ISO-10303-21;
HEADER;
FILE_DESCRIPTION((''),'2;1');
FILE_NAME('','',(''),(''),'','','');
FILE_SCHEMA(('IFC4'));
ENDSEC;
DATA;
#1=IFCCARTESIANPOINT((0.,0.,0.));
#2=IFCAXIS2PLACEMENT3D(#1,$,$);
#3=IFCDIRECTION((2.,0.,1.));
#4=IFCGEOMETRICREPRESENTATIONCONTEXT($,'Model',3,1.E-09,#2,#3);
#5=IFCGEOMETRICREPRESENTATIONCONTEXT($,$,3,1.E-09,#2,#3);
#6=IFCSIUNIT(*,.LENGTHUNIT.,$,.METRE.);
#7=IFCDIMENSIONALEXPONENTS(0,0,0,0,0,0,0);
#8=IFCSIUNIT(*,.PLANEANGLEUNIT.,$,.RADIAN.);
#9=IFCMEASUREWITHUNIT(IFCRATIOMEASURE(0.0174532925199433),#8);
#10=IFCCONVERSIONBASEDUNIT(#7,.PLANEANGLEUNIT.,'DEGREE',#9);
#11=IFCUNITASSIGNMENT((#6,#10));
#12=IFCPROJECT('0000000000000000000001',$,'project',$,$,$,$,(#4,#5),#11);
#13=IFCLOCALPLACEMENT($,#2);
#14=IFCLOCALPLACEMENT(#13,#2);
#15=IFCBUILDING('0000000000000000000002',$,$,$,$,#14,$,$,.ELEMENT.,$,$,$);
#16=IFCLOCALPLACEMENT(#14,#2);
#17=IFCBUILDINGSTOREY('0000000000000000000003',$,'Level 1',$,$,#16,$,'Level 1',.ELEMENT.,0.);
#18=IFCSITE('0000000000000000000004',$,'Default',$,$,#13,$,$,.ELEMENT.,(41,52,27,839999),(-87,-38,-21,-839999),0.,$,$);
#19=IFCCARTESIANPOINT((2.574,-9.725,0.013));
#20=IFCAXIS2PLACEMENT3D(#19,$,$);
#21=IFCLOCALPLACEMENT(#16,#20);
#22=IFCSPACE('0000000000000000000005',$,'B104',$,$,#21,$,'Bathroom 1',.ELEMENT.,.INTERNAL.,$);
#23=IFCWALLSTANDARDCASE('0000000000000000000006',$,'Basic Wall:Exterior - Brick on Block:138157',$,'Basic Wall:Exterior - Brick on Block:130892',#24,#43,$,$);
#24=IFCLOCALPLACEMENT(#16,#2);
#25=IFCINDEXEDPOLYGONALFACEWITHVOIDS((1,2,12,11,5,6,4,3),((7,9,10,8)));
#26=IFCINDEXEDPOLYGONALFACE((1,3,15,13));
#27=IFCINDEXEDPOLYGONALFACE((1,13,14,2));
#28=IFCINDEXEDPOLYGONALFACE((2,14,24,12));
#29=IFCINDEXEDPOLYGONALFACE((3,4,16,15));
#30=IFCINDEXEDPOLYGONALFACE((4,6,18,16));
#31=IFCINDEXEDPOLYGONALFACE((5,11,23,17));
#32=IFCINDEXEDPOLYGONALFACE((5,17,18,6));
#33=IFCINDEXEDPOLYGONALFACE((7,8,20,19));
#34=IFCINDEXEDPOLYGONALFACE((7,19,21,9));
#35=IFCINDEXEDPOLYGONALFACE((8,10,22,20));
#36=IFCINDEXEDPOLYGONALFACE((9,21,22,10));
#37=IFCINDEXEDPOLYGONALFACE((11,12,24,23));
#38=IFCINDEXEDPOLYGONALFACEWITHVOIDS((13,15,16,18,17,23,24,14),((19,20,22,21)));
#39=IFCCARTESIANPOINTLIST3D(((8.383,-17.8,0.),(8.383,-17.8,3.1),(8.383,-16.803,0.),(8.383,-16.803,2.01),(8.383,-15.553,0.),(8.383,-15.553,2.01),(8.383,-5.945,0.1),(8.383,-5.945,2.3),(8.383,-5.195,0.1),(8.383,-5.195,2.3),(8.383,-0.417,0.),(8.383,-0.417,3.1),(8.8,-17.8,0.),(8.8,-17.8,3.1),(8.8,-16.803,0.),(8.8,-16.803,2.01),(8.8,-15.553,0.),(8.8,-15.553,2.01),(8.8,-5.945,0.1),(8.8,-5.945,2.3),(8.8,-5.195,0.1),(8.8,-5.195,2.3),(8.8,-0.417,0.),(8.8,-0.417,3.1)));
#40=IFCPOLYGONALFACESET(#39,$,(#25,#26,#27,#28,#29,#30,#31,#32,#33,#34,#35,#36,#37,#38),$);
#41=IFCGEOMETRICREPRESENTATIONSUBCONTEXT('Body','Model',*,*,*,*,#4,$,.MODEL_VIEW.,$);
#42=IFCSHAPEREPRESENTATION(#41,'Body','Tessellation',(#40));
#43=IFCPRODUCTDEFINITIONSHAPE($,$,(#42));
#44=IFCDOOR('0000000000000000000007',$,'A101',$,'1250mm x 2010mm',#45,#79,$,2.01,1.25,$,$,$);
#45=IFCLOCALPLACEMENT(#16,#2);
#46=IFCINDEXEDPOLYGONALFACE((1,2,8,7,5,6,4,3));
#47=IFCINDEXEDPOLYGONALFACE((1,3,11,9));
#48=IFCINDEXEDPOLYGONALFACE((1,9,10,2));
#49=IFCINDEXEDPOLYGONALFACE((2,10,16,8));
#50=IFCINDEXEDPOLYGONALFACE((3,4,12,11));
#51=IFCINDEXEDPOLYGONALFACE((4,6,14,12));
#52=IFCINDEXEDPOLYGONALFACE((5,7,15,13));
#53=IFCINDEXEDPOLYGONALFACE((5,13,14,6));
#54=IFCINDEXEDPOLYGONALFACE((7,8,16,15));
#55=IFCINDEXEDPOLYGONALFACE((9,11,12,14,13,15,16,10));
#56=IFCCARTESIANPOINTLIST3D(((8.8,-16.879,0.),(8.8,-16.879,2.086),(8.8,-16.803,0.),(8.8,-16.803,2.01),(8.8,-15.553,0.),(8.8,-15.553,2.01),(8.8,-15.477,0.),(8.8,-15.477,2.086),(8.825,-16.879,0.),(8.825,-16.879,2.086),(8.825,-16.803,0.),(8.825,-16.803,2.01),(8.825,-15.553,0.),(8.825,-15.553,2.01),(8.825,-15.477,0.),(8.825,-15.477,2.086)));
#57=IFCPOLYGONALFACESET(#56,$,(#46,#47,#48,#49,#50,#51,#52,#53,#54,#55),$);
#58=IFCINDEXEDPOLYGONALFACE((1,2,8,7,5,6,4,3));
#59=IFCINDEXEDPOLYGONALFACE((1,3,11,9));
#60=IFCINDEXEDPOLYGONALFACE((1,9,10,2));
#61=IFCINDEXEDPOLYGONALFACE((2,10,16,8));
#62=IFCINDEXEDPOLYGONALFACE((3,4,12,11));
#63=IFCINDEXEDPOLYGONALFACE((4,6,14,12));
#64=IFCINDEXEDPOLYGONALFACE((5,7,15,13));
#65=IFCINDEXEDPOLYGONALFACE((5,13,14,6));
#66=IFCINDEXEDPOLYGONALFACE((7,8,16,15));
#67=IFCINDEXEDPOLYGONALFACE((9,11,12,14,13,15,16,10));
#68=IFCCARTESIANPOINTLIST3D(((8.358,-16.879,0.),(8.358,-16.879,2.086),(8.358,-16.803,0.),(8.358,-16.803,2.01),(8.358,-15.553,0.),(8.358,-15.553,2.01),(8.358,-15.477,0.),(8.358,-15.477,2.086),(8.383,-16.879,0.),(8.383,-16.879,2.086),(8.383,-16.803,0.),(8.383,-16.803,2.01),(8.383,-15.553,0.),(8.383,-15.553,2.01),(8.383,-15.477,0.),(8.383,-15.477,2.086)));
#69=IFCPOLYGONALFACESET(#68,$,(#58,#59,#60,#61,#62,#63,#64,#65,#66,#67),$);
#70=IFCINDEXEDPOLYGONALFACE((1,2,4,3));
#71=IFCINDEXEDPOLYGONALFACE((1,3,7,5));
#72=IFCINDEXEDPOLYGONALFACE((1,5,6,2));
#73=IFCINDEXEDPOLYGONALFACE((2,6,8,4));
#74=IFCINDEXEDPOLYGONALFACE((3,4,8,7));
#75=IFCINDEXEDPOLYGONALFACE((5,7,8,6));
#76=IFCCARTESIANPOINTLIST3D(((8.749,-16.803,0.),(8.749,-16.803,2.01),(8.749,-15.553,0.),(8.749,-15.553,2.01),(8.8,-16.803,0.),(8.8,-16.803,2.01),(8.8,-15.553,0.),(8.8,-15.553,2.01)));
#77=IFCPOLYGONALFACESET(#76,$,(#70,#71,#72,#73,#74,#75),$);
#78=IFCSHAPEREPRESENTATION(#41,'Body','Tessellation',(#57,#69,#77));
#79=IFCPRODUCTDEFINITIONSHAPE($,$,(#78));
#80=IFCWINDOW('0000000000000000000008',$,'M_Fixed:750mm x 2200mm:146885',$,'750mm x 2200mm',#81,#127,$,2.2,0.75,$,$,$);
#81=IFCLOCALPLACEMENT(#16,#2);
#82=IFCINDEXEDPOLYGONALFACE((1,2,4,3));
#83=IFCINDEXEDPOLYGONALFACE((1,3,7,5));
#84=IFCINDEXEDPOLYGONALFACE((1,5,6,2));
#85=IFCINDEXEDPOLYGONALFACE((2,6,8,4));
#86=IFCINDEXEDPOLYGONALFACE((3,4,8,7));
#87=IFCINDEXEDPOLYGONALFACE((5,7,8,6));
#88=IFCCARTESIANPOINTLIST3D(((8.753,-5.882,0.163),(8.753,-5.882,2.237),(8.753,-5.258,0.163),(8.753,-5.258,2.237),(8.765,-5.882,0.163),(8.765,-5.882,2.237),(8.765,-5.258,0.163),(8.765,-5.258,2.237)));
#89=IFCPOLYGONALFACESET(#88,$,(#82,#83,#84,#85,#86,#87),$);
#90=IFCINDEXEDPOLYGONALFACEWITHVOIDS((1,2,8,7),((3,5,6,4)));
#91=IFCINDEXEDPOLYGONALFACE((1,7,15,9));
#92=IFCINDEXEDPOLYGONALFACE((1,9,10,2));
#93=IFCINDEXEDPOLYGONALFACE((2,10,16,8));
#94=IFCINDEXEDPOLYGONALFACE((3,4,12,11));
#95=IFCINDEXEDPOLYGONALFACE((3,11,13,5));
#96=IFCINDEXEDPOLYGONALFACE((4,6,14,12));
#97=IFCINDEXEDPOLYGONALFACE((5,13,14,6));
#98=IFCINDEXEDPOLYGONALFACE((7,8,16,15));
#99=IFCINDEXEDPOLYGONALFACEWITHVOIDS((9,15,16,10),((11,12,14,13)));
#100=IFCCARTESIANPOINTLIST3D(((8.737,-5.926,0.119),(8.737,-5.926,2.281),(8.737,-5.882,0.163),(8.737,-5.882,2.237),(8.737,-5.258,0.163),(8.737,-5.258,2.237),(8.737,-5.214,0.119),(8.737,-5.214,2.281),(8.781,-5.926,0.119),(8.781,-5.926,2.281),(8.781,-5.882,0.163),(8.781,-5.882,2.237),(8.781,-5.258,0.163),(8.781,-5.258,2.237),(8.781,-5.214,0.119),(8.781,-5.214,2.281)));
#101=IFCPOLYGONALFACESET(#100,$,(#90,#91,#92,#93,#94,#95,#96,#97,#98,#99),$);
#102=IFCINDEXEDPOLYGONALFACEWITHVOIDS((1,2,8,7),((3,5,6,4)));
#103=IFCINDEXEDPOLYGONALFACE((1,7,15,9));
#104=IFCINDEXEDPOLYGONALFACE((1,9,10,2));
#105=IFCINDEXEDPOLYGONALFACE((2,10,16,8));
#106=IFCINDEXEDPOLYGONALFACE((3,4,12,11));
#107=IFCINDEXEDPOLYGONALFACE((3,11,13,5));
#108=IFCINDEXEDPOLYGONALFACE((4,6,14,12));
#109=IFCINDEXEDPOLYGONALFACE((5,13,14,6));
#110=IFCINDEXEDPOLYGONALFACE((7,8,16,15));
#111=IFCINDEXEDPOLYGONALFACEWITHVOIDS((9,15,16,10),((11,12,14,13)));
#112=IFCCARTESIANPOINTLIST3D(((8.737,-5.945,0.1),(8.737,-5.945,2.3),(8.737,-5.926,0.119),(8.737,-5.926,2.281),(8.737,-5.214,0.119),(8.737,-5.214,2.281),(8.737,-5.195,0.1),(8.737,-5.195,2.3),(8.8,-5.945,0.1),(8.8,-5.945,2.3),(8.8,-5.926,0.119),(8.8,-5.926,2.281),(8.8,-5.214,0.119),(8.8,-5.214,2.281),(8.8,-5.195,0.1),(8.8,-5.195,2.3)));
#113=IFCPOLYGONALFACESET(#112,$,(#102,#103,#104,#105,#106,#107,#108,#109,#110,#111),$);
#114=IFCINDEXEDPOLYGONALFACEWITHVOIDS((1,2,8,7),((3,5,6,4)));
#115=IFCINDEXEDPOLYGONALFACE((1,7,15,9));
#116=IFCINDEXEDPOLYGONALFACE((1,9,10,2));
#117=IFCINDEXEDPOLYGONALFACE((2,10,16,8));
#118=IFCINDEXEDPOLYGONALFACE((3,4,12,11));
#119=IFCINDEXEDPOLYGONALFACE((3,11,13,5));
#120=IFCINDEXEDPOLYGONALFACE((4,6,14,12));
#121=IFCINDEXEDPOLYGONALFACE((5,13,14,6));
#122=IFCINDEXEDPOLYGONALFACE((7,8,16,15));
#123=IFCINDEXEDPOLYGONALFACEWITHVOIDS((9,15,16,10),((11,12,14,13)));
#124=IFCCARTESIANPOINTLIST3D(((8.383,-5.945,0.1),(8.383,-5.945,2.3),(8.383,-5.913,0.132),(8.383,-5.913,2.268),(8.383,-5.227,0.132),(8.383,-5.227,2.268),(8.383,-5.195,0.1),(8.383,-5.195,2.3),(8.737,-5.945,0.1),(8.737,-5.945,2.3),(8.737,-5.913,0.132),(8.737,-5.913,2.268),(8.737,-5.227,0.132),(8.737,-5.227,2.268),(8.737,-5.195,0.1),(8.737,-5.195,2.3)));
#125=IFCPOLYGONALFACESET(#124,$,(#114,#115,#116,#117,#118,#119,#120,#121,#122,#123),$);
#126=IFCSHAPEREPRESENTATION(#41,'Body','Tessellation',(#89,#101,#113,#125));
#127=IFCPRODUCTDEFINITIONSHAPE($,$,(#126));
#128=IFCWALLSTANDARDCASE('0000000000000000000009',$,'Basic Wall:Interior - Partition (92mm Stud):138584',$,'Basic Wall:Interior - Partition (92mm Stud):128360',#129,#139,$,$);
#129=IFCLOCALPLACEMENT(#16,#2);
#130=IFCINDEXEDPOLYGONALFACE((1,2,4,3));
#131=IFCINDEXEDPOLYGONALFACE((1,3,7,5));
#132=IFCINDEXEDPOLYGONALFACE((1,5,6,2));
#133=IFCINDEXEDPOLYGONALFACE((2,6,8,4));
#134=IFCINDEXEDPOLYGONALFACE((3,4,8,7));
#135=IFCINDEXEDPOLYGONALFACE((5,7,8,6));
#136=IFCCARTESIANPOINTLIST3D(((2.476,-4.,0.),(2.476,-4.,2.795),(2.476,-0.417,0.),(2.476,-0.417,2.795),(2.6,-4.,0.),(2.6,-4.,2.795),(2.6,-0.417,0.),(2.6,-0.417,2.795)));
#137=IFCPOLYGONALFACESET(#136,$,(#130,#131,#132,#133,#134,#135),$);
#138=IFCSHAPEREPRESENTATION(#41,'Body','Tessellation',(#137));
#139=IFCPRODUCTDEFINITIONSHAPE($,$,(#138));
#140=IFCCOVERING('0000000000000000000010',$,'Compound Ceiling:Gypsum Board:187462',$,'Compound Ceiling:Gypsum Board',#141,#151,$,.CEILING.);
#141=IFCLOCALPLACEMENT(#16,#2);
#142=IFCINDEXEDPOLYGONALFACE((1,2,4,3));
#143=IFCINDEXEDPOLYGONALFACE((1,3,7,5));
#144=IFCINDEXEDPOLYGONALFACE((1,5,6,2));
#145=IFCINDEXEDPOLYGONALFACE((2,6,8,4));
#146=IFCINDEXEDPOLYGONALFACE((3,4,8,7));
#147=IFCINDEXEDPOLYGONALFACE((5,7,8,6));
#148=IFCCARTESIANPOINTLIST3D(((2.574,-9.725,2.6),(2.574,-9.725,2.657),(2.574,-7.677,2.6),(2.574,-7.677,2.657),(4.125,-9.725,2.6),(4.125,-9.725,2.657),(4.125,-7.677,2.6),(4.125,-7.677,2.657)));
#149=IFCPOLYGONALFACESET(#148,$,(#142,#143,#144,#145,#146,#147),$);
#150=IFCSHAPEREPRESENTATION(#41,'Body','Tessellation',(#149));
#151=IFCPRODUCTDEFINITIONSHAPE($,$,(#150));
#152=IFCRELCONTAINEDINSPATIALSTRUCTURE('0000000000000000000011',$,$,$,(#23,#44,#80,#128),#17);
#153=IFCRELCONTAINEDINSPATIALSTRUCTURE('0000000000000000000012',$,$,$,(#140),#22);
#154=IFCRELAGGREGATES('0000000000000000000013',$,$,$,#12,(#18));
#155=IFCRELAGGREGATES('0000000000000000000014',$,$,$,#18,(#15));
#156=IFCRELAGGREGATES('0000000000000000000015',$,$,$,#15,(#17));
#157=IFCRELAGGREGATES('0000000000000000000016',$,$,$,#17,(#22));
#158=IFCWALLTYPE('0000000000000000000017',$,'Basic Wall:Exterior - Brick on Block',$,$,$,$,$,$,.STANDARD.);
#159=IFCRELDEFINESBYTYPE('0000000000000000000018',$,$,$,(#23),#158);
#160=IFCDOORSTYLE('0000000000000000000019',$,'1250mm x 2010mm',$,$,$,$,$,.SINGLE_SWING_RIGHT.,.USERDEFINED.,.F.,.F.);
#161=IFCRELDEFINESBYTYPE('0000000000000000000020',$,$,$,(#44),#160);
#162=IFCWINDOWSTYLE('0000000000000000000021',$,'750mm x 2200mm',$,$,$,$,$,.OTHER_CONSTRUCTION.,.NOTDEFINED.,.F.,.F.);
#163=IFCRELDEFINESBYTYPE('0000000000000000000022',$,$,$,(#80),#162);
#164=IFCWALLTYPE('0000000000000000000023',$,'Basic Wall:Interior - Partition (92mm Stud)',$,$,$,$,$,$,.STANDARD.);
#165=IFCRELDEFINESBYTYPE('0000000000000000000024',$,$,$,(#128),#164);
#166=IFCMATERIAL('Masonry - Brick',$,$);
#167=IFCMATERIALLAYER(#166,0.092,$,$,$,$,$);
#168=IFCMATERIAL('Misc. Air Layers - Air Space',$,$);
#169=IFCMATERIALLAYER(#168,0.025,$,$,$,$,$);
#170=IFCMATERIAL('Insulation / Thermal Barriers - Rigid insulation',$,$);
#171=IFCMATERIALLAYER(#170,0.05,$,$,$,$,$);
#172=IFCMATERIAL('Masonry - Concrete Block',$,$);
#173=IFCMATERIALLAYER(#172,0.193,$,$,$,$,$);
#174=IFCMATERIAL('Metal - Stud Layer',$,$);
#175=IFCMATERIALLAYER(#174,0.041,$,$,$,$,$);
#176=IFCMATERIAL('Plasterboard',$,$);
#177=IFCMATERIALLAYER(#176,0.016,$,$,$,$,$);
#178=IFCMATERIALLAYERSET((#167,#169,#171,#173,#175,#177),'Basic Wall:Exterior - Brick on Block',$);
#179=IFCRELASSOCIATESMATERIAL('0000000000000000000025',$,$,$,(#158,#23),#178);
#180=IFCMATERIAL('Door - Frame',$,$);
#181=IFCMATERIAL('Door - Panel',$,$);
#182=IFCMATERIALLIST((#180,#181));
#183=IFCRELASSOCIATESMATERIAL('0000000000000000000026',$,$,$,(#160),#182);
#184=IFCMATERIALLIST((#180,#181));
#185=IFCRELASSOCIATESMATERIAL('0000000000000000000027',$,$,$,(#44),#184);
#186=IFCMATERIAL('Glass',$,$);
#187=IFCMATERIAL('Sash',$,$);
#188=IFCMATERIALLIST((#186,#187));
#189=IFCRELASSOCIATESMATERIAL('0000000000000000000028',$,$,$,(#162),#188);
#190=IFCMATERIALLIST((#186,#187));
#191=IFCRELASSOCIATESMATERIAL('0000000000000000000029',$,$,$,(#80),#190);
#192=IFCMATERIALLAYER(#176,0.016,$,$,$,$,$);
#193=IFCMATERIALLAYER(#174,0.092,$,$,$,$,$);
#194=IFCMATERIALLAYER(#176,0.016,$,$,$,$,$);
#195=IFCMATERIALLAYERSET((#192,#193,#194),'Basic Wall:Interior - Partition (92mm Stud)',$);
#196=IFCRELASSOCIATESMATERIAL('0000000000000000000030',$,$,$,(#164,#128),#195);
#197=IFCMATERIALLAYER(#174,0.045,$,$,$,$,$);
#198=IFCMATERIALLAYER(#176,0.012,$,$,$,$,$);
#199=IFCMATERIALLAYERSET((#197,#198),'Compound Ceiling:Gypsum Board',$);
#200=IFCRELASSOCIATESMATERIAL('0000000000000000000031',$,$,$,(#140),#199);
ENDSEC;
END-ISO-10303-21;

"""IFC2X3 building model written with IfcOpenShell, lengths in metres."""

from ifc_helpers import new_model, entity, si_unit, converted_unit, direction, frame, frame_2d, origin, origin_2d_with_axis, place, context, subcontext, project, spatial, polyline, rectangle, outline, extrude, source, transform, mapped, material, material_list, layer, layer_set, layer_usage, type_object, type_shapes, element, fill, save


model = new_model("IFC2X3")

# Units and contexts
model_context = context("Model", 3, precision=1e-09, world=origin(), true_north=direction((2.0, 0.0, 1.0)))
context_of_model = context(None, 3, precision=1e-09, world=origin(), true_north=direction((2.0, 0.0, 1.0)))
body_context = subcontext(model_context, "Body", "Model", "MODEL_VIEW")
ifc_project = project(units=[si_unit("LENGTHUNIT", "METRE"), converted_unit("PLANEANGLEUNIT", "DEGREE", entity("IfcRatioMeasure", 0.0174532925199433), si_unit("PLANEANGLEUNIT", "RADIAN"), dimensions=[0, 0, 0, 0, 0, 0, 0])], contexts=[model_context, context_of_model])

# Site, building, storey
site_placement = place(None, origin())
site = spatial("IfcSite", under=ifc_project, at=site_placement, Name="Default", CompositionType="ELEMENT", RefLatitude=(41, 52, 27, 839999), RefLongitude=(-87, -38, -21, -839999), RefElevation=0.0)
building_placement = place(site_placement, origin())
building = spatial("IfcBuilding", under=site, at=building_placement, CompositionType="ELEMENT")
storey_placement = place(building_placement, origin())
storey = spatial("IfcBuildingStorey", under=building, at=storey_placement, Name="Level 1", LongName="Level 1", CompositionType="ELEMENT", Elevation=0.0)

# Shared definitions
ifc_material_1 = material(Name="Masonry - Brick")
ifc_layer_1 = layer(ifc_material_1, 0.092)
ifc_material_2 = material(Name="Misc. Air Layers - Air Space")
ifc_layer_2 = layer(ifc_material_2, 0.025)
ifc_material_3 = material(Name="Insulation / Thermal Barriers - Rigid insulation")
ifc_layer_3 = layer(ifc_material_3, 0.05)
ifc_material_4 = material(Name="Masonry - Concrete Block")
ifc_layer_4 = layer(ifc_material_4, 0.193)
ifc_material_5 = material(Name="Metal - Stud Layer")
ifc_layer_5 = layer(ifc_material_5, 0.041)
ifc_material_6 = material(Name="Plasterboard")
ifc_layer_6 = layer(ifc_material_6, 0.016)
ifc_layer_set_1 = layer_set([ifc_layer_1, ifc_layer_2, ifc_layer_3, ifc_layer_4, ifc_layer_5, ifc_layer_6], Name="Basic Wall:Exterior - Brick on Block")
wall_type_1 = type_object("IfcWallType", Name="Basic Wall:Exterior - Brick on Block", PredefinedType="STANDARD", material=ifc_layer_set_1)
ifc_material_7 = material(Name="Glass")
ifc_material_8 = material(Name="Sash")
ifc_material_9 = material(Name="Door - Frame")
ifc_material_10 = material(Name="Door - Panel")

# Wall, openings, door, window
ifc_layer_usage_1 = layer_usage(ifc_layer_set_1, "AXIS2", "NEGATIVE", 0.2085)
wall_1_placement = place(storey_placement, frame((8.5915, -0.417, 0.0), z_axis=(0.0, 0.0, 1.0), x_axis=(0.0, -1.0, 0.0)))
wall_1 = element("IfcWallStandardCase", 1, at=wall_1_placement, inside=storey, type_object=wall_type_1, material=ifc_layer_usage_1, Name="Basic Wall:Exterior - Brick on Block:138157", ObjectType="Basic Wall:Exterior - Brick on Block:130892", context=body_context, shape_type="SweptSolid", body=[
    extrude(rectangle(XDim=17.383, YDim=0.417, at=frame_2d((8.6915, 0.0), x_axis=(-1.0, 0.0))), origin(), (0.0, 0.0, 1.0), 3.1),
])
opening_1_placement = place(wall_1_placement, frame((15.136, -0.2085, 0.0)))
opening_1 = element("IfcOpeningElement", 2, at=opening_1_placement, cuts=wall_1, ObjectType="Opening", context=body_context, shape_type="SweptSolid", body=[
    extrude(rectangle(XDim=1.25, YDim=2.01, at=frame_2d((1.005, 0.625), x_axis=(0.0, 1.0))), frame((0.0, 0.0, 0.0), z_axis=(0.0, 1.0, 0.0), x_axis=(0.0, 0.0, 1.0)), (0.0, 0.0, 1.0), 0.417),
])
opening_2_placement = place(wall_1_placement, frame((4.778, -0.2085, 0.1)))
opening_2 = element("IfcOpeningElement", 3, at=opening_2_placement, cuts=wall_1, ObjectType="Opening", context=body_context, shape_type="SweptSolid", body=[
    extrude(rectangle(XDim=2.2, YDim=0.75, at=frame_2d((1.1, 0.375), x_axis=(1.0, 0.0))), frame((0.0, 0.0, 0.0), z_axis=(0.0, 1.0, 0.0), x_axis=(0.0, 0.0, 1.0)), (0.0, 0.0, 1.0), 0.417),
])
ifc_material_list_1 = material_list([ifc_material_9, ifc_material_10])
ifc_material_list_2 = material_list([ifc_material_9, ifc_material_10])
door_style_1 = type_object("IfcDoorStyle", Name="1250mm x 2010mm", ConstructionType="USERDEFINED", OperationType="SINGLE_SWING_RIGHT", ParameterTakesPrecedence=False, Sizeable=False, material=ifc_material_list_2)
shared_shape_1 = source(origin(), body_context, "Body", "SweptSolid", [
    extrude(outline(polyline([(-0.701, -1.062), (0.701, -1.062), (0.701, 1.024), (0.625, 1.024), (0.625, -0.986), (-0.625, -0.986), (-0.625, 1.024), (-0.701, 1.024), (-0.701, -1.062)])), frame((0.625, 0.417, 1.024), z_axis=(0.0, 1.0, 0.0), x_axis=(1.0, 0.0, 0.0)), (0.0, 0.0, 1.0), 0.025),
    extrude(outline(polyline([(-1.062, -0.701), (1.024, -0.701), (1.024, -0.625), (-0.986, -0.625), (-0.986, 0.625), (1.024, 0.625), (1.024, 0.701), (-1.062, 0.701), (-1.062, -0.701)])), frame((0.625, -0.025, 1.024), z_axis=(0.0, 1.0, 0.0), x_axis=(0.0, 0.0, -1.0)), (0.0, 0.0, 1.0), 0.025),
    extrude(rectangle(XDim=0.051, YDim=1.25, at=frame_2d((0.0, 0.0), x_axis=(1.0, 0.0))), frame((0.625, 0.3915, 0.0), z_axis=(0.0, 0.0, 1.0), x_axis=(0.0, 1.0, 0.0)), (0.0, 0.0, 1.0), 2.01),
])
type_shapes(door_style_1, [shared_shape_1])
door_1_placement = place(opening_1_placement, origin())
door_1 = element("IfcDoor", 4, at=door_1_placement, inside=storey, type_object=door_style_1, material=ifc_material_list_1, Name="A101", ObjectType="1250mm x 2010mm", OverallHeight=2.01, OverallWidth=1.25, context=body_context, shape_type="MappedRepresentation", body=[
    mapped(shared_shape_1, transform((0.0, 0.0, 0.0), scale=1.0)),
])
fill(opening_1, door_1)
ifc_material_list_3 = material_list([ifc_material_7, ifc_material_8])
ifc_material_list_4 = material_list([ifc_material_7, ifc_material_8])
window_style_1 = type_object("IfcWindowStyle", Name="750mm x 2200mm", ConstructionType="OTHER_CONSTRUCTION", OperationType="NOTDEFINED", ParameterTakesPrecedence=False, Sizeable=False, material=ifc_material_list_4)
shared_shape_2 = source(origin(), body_context, "Body", "SweptSolid", [
    extrude(rectangle(XDim=0.012, YDim=0.624, at=origin_2d_with_axis()), frame((0.375, 0.376, 0.063), z_axis=(0.0, 0.0, 1.0), x_axis=(0.0, -1.0, 0.0)), (0.0, 0.0, 1.0), 2.074),
    extrude(outline(polyline([(-0.356, -1.081), (0.356, -1.081), (0.356, 1.081), (-0.356, 1.081), (-0.356, -1.081)]), holes=[polyline([(-0.312, -1.037), (-0.312, 1.037), (0.312, 1.037), (0.312, -1.037), (-0.312, -1.037)])]), frame((0.375, 0.354, 1.1), z_axis=(0.0, 1.0, 0.0), x_axis=(1.0, 0.0, 0.0)), (0.0, 0.0, 1.0), 0.044),
    extrude(outline(polyline([(-0.375, -1.1), (0.375, -1.1), (0.375, 1.1), (-0.375, 1.1), (-0.375, -1.1)]), holes=[polyline([(-0.356, -1.081), (-0.356, 1.081), (0.356, 1.081), (0.356, -1.081), (-0.356, -1.081)])]), frame((0.375, 0.354, 1.1), z_axis=(0.0, 1.0, 0.0), x_axis=(1.0, 0.0, 0.0)), (0.0, 0.0, 1.0), 0.063),
    extrude(outline(polyline([(-0.375, -1.1), (0.375, -1.1), (0.375, 1.1), (-0.375, 1.1), (-0.375, -1.1)]), holes=[polyline([(-0.343, -1.068), (-0.343, 1.068), (0.343, 1.068), (0.343, -1.068), (-0.343, -1.068)])]), frame((0.375, 0.0, 1.1), z_axis=(0.0, 1.0, 0.0), x_axis=(1.0, 0.0, 0.0)), (0.0, 0.0, 1.0), 0.354),
])
type_shapes(window_style_1, [shared_shape_2])
window_1_placement = place(opening_2_placement, origin())
window_1 = element("IfcWindow", 5, at=window_1_placement, inside=storey, type_object=window_style_1, material=ifc_material_list_3, Name="M_Fixed:750mm x 2200mm:146885", ObjectType="750mm x 2200mm", OverallHeight=2.2, OverallWidth=0.75, context=body_context, shape_type="MappedRepresentation", body=[
    mapped(shared_shape_2, transform((0.0, 0.0, 0.0), scale=1.0)),
])
fill(opening_2, window_1)

# Wall
ifc_layer_7 = layer(ifc_material_6, 0.016)
ifc_layer_8 = layer(ifc_material_5, 0.092)
ifc_layer_9 = layer(ifc_material_6, 0.016)
ifc_layer_set_2 = layer_set([ifc_layer_7, ifc_layer_8, ifc_layer_9], Name="Basic Wall:Interior - Partition (92mm Stud)")
ifc_layer_usage_2 = layer_usage(ifc_layer_set_2, "AXIS2", "NEGATIVE", 0.062)
wall_type_2 = type_object("IfcWallType", Name="Basic Wall:Interior - Partition (92mm Stud)", PredefinedType="STANDARD", material=ifc_layer_set_2)
wall_2_placement = place(storey_placement, frame((2.538, -0.417, 0.0), z_axis=(0.0, 0.0, 1.0), x_axis=(0.0, -1.0, 0.0)))
element("IfcWallStandardCase", 6, at=wall_2_placement, inside=storey, type_object=wall_type_2, material=ifc_layer_usage_2, Name="Basic Wall:Interior - Partition (92mm Stud):138584", ObjectType="Basic Wall:Interior - Partition (92mm Stud):128360", context=body_context, shape_type="SweptSolid", body=[
    extrude(rectangle(XDim=3.583, YDim=0.124, at=frame_2d((1.7915, 0.0), x_axis=(-1.0, 0.0))), origin(), (0.0, 0.0, 1.0), 2.795),
])

# Shared definitions
ifc_layer_10 = layer(ifc_material_5, 0.045)
ifc_layer_11 = layer(ifc_material_6, 0.012)
ifc_layer_set_3 = layer_set([ifc_layer_10, ifc_layer_11], Name="Compound Ceiling:Gypsum Board")

# Shared definitions
space_1_placement = place(storey_placement, frame((2.574, -9.725, 0.013)))
space_1 = spatial("IfcSpace", under=storey, at=space_1_placement, Name="B104", LongName="Bathroom 1", CompositionType="ELEMENT", InteriorOrExteriorSpace="INTERNAL")

# Covering
ifc_layer_usage_3 = layer_usage(ifc_layer_set_3, "AXIS3", "NEGATIVE", 0.0)
covering_1_placement = place(space_1_placement, frame((-2.574, 9.725, -0.013)))
element("IfcCovering", 7, at=covering_1_placement, inside=space_1, material=ifc_layer_usage_3, Name="Compound Ceiling:Gypsum Board:187462", ObjectType="Compound Ceiling:Gypsum Board", PredefinedType="CEILING", context=body_context, shape_type="SweptSolid", body=[
    extrude(rectangle(XDim=1.551, YDim=2.048, at=frame_2d((0.0, 0.0), x_axis=(1.0, 0.0))), frame((3.3495, -8.701, 2.6)), (0.0, 0.0, 1.0), 0.057),
])

save(model, "model.ifc")
